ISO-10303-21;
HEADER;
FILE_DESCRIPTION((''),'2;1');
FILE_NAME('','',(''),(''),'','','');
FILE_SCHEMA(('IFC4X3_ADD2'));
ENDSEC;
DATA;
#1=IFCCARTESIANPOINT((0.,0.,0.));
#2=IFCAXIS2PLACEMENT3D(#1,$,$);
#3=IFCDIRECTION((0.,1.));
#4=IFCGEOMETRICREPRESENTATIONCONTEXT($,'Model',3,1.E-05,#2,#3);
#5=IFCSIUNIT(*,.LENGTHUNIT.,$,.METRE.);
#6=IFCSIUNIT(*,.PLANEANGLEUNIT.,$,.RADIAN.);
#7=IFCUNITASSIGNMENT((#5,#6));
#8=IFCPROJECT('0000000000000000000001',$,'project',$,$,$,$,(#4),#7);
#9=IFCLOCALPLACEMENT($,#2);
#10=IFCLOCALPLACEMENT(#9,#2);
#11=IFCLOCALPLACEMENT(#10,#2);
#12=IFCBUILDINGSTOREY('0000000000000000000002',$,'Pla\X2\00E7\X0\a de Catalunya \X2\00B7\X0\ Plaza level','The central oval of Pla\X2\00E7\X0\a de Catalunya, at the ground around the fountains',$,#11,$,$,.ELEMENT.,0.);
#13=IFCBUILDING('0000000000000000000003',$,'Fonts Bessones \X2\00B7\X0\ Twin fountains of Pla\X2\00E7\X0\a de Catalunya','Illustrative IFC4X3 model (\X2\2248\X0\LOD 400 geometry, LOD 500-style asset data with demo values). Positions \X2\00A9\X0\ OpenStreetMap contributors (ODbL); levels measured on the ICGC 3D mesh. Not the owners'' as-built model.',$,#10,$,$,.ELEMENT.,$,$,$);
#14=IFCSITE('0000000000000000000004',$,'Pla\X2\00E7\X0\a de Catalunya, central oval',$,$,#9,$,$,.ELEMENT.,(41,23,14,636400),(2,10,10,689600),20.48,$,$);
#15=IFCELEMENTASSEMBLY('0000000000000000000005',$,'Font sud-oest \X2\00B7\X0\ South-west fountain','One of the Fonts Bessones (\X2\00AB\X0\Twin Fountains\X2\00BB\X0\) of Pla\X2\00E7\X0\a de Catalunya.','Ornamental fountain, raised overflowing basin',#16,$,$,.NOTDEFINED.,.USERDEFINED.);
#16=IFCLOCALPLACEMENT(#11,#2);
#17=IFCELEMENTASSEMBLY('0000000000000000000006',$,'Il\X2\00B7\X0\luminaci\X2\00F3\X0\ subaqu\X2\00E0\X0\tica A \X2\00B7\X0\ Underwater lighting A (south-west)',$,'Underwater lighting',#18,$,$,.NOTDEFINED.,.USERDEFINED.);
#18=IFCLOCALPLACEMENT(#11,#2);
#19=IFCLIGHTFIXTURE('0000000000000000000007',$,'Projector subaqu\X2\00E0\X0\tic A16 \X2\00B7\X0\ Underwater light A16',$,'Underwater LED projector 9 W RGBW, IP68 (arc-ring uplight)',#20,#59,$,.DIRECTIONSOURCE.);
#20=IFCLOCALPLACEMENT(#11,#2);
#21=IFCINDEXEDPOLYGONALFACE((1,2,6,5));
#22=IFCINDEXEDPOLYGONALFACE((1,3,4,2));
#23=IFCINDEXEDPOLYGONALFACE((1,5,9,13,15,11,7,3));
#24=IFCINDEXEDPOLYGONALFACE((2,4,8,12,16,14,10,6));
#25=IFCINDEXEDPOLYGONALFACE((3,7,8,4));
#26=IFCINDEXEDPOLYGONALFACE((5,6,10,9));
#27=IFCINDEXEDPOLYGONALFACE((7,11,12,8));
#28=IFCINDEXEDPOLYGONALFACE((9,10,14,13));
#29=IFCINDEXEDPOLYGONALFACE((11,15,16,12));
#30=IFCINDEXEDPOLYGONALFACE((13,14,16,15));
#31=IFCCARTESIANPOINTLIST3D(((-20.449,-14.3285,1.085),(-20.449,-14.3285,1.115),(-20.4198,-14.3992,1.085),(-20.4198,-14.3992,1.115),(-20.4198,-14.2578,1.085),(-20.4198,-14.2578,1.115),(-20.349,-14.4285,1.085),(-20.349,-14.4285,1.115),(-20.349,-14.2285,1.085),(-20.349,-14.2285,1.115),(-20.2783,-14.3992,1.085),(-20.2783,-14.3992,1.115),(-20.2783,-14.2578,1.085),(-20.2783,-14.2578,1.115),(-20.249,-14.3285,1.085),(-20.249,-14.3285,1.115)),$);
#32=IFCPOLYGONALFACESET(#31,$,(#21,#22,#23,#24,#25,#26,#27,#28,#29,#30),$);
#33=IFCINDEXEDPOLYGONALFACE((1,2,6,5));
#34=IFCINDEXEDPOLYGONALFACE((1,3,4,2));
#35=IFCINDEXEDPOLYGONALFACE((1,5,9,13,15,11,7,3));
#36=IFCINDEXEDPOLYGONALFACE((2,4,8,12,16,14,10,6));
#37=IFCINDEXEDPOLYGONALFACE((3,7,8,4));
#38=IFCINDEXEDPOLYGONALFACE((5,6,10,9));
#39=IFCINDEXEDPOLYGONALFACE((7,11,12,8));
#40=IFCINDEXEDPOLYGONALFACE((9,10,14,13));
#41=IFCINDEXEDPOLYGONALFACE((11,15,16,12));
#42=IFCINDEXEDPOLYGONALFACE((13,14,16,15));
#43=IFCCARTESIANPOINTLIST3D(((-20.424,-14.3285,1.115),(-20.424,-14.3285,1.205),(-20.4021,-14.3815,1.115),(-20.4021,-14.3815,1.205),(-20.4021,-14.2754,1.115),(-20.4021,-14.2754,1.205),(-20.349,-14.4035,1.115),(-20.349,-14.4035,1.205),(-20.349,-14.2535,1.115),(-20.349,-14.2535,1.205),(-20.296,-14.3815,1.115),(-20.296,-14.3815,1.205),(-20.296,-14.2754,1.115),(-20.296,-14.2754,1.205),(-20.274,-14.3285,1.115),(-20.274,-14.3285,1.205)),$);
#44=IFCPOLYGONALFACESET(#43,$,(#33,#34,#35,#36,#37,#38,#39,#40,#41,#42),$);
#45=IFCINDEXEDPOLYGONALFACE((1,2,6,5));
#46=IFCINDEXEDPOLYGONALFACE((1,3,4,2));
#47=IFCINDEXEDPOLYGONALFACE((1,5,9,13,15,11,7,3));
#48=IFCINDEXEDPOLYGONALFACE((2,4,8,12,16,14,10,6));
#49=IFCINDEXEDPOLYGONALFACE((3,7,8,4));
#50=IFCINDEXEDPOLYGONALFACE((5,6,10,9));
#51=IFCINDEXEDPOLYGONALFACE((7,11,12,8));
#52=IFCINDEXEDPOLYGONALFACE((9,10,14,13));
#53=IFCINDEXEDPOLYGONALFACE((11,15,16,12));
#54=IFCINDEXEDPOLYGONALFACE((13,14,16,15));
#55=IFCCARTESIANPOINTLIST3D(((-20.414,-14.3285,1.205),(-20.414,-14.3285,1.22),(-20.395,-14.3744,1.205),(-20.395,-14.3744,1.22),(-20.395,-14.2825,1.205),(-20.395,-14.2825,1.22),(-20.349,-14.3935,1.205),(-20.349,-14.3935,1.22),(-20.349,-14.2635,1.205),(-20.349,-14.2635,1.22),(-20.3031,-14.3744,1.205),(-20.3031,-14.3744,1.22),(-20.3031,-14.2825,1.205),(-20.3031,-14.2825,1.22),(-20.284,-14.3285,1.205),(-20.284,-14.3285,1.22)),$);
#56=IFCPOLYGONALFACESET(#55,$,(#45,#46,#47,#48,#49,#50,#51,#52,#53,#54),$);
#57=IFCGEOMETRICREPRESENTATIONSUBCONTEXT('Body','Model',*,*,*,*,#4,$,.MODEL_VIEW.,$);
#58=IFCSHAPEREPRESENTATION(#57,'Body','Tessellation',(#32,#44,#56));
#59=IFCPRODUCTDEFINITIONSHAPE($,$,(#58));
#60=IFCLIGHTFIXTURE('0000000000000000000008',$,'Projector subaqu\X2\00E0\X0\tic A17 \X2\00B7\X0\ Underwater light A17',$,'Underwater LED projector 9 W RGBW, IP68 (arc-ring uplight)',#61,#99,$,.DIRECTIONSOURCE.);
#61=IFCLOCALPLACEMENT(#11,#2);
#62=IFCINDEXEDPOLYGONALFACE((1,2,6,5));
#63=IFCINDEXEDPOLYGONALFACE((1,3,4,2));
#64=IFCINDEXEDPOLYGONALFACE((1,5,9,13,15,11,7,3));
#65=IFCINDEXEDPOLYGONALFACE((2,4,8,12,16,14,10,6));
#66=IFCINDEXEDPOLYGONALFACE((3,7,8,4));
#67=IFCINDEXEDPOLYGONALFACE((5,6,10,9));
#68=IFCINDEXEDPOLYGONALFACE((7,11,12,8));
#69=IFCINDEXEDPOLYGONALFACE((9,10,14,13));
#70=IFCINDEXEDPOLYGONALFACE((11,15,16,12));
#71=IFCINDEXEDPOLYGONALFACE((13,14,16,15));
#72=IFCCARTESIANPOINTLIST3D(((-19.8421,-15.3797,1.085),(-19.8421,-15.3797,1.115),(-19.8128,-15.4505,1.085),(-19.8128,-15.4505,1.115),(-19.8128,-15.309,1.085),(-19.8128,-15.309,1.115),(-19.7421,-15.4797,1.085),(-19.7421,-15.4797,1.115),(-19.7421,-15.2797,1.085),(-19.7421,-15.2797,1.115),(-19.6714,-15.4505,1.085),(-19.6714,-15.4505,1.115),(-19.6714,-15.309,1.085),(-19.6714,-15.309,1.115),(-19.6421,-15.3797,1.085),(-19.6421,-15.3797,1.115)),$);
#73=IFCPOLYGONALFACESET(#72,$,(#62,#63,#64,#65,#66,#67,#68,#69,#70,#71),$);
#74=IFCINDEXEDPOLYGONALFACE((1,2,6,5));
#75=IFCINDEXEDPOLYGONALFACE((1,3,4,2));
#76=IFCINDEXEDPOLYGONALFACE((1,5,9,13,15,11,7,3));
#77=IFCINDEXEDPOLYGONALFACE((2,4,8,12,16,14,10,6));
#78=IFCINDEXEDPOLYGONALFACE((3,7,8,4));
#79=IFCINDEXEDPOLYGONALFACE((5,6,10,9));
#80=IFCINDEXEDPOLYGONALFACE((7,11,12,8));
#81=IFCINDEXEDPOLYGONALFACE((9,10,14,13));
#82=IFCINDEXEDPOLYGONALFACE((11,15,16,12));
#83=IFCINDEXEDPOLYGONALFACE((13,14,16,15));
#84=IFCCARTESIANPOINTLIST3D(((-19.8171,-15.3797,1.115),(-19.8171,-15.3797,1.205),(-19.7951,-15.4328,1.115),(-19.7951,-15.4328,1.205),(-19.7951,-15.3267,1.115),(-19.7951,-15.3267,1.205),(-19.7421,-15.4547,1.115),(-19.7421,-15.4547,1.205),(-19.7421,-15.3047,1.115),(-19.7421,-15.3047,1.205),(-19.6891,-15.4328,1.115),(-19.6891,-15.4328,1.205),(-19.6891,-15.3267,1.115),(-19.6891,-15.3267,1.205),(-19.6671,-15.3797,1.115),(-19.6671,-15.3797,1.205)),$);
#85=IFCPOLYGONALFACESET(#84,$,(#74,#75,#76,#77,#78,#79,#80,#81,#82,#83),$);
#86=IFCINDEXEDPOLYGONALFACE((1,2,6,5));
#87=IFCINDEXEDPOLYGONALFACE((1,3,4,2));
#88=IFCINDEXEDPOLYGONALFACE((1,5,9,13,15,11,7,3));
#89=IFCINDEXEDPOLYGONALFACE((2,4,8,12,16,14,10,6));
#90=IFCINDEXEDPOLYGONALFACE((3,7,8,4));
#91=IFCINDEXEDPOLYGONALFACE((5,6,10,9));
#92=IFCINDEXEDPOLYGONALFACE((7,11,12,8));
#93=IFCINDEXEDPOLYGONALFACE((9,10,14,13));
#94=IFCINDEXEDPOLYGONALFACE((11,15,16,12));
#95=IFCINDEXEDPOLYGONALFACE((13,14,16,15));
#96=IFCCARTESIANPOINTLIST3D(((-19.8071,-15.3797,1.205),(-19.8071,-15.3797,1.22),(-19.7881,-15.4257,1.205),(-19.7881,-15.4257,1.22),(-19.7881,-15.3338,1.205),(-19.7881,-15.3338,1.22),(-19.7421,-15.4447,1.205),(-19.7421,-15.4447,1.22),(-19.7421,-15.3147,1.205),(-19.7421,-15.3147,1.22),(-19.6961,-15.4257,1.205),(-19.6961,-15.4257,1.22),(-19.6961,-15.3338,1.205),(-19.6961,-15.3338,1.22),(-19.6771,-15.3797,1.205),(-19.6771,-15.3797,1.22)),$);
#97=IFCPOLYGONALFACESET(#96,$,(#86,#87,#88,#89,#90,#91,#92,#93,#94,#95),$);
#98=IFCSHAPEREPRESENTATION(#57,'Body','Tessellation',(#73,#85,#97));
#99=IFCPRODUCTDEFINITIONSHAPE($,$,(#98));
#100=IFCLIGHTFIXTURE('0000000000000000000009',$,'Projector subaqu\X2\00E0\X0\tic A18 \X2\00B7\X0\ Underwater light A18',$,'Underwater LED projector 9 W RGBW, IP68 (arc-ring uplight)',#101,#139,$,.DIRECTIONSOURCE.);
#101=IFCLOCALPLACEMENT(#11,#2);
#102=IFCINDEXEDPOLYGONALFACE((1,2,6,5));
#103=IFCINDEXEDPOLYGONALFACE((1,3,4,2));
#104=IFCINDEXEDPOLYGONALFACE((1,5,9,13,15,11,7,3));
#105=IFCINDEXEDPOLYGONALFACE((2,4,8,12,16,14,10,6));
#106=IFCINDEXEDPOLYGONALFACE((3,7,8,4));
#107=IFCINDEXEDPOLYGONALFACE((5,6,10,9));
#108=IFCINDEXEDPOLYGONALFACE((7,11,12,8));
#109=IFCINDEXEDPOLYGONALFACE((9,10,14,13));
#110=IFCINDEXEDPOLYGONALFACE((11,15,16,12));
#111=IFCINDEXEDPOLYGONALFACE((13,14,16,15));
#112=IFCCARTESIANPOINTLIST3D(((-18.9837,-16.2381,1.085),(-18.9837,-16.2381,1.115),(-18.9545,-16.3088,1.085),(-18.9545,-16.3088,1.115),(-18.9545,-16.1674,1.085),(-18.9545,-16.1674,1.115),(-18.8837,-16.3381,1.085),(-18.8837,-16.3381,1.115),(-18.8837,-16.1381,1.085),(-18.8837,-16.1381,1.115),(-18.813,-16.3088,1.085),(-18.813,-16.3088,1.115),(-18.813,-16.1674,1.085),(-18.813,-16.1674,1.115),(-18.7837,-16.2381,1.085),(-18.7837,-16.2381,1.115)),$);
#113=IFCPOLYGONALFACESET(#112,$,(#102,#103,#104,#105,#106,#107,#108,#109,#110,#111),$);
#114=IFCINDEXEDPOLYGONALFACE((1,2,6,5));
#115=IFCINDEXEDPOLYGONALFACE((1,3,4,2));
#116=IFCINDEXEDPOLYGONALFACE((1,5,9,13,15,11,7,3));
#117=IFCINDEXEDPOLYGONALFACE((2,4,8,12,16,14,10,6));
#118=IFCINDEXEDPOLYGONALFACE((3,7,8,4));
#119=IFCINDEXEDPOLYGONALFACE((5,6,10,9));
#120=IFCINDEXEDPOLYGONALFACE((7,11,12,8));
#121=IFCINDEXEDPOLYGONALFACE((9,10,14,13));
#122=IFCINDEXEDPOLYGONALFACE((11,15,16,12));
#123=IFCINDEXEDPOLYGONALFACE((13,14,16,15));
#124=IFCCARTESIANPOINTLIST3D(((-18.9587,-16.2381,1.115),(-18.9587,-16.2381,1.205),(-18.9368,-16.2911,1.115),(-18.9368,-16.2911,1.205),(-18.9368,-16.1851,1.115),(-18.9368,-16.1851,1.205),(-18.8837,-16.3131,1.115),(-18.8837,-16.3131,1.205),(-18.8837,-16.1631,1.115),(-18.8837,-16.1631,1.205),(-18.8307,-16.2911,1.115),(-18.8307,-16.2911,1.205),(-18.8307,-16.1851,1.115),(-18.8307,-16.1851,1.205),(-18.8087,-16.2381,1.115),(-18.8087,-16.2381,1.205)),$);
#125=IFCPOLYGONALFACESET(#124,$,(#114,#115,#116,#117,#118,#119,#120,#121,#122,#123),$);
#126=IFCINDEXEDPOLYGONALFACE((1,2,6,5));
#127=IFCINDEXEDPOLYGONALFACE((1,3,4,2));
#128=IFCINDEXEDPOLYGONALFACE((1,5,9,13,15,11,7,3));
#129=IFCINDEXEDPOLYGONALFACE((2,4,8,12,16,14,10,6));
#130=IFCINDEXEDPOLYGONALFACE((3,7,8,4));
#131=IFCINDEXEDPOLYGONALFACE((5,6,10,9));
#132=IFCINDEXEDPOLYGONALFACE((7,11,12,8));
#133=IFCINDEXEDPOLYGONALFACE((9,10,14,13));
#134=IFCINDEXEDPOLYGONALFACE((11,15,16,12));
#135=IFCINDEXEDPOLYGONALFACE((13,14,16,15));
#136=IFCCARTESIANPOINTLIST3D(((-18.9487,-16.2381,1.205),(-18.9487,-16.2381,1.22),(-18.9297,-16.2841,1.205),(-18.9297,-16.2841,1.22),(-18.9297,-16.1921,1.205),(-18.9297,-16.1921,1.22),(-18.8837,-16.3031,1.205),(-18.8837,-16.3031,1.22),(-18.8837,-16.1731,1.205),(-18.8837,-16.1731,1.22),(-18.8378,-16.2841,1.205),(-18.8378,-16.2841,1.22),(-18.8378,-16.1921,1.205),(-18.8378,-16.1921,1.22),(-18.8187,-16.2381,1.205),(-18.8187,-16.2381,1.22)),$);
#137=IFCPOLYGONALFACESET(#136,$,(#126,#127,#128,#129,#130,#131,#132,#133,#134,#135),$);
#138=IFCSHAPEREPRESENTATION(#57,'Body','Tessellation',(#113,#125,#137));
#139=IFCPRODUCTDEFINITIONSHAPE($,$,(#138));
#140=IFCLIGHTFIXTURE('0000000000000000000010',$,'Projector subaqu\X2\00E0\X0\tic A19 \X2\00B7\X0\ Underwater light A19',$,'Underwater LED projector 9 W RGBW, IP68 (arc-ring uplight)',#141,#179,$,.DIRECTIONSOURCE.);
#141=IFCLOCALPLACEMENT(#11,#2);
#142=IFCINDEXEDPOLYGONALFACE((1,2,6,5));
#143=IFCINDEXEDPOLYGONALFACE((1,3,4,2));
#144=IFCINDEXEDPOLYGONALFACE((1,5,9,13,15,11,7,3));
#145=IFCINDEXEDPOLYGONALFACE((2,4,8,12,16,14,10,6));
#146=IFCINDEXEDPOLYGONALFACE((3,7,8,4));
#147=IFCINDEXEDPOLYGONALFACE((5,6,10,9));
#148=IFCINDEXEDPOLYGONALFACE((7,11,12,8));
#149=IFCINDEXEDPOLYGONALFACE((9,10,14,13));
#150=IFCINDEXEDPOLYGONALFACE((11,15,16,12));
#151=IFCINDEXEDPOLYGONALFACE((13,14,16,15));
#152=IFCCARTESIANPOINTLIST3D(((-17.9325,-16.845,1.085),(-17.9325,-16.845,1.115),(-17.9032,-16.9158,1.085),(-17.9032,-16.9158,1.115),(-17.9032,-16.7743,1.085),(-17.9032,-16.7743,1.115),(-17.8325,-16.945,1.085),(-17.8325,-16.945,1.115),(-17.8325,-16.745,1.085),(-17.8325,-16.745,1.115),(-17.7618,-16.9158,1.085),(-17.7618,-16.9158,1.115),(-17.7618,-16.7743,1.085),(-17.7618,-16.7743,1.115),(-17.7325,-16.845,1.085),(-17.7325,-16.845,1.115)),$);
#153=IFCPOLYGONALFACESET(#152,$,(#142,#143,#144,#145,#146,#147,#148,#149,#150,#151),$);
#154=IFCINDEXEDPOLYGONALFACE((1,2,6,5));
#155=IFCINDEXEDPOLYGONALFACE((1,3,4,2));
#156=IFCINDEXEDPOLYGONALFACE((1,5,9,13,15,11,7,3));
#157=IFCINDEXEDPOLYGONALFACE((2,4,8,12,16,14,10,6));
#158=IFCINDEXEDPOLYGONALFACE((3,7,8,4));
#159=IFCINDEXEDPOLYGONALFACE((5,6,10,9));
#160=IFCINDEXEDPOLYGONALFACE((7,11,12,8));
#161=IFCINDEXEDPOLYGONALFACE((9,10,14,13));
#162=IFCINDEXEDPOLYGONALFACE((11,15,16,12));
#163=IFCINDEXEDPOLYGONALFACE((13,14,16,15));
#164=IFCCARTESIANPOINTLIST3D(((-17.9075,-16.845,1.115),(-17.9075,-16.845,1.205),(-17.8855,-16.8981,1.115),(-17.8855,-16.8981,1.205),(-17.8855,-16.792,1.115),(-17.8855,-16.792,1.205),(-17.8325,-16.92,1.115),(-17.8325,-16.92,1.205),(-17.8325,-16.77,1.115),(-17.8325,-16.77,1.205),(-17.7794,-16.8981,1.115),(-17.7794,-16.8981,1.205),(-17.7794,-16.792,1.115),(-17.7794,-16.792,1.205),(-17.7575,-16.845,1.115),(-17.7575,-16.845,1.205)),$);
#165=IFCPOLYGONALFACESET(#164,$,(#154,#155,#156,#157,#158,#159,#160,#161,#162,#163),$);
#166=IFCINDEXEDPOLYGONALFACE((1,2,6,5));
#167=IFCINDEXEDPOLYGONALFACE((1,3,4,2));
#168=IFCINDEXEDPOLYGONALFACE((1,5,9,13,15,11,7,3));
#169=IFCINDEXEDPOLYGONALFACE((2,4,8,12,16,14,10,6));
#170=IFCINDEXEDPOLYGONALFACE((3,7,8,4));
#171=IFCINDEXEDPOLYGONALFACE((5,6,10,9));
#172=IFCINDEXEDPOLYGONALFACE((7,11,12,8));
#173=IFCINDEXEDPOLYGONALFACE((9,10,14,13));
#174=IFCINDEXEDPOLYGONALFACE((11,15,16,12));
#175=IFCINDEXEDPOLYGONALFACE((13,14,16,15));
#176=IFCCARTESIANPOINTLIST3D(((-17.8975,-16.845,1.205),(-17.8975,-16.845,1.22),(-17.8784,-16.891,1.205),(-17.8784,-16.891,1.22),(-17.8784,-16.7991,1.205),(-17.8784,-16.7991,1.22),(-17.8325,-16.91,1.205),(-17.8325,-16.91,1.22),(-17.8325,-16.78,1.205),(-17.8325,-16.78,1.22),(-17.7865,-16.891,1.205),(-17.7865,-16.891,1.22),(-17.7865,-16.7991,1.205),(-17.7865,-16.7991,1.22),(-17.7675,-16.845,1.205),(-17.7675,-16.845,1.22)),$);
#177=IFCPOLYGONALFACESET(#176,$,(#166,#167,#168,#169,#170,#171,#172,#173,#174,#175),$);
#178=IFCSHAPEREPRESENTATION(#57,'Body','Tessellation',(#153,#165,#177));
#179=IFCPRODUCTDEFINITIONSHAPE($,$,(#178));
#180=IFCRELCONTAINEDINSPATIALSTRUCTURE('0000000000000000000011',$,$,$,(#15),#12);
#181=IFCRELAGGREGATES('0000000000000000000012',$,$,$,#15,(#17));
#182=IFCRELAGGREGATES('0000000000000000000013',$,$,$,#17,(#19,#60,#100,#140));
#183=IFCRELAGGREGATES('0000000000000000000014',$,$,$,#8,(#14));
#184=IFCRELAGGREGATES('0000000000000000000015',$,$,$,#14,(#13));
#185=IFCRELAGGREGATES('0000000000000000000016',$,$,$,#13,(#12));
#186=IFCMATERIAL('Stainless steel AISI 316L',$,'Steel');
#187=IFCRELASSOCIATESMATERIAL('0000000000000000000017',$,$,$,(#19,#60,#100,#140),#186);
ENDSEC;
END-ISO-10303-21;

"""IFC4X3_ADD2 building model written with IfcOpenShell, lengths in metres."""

from ifc_helpers import new_model, si_unit, direction, frame, origin, place, context, subcontext, project, spatial, polyline, outline, extrude, material, element, aggregate, save


model = new_model("IFC4X3_ADD2")

# Units and contexts
model_context = context("Model", 3, precision=1e-05, world=origin(), true_north=direction((0.0, 1.0)))
body_context = subcontext(model_context, "Body", "Model", "MODEL_VIEW")
ifc_project = project(units=[si_unit("LENGTHUNIT", "METRE"), si_unit("PLANEANGLEUNIT", "RADIAN")], contexts=[model_context])

# Site, building, storey
site_placement = place(None, origin())
site = spatial("IfcSite", under=ifc_project, at=site_placement, Name="Plaça de Catalunya, central oval", CompositionType="ELEMENT", RefLatitude=(41, 23, 14, 636400), RefLongitude=(2, 10, 10, 689600), RefElevation=20.48)
building_placement = place(site_placement, origin())
building = spatial("IfcBuilding", under=site, at=building_placement, Name="Fonts Bessones · Twin fountains of Plaça de Catalunya", Description="Illustrative IFC4X3 model (≈LOD 400 geometry, LOD 500-style asset data with demo values). Positions © OpenStreetMap contributors (ODbL); levels measured on the ICGC 3D mesh. Not the owners' as-built model.", CompositionType="ELEMENT")
storey_placement = place(building_placement, origin())
storey = spatial("IfcBuildingStorey", under=building, at=storey_placement, Name="Plaça de Catalunya · Plaza level", Description="The central oval of Plaça de Catalunya, at the ground around the fountains", CompositionType="ELEMENT", Elevation=0.0)

# Element assemblies, light fixtures
assembly_1_placement = place(building_placement, origin())
assembly_1 = element("IfcElementAssembly", 1, at=assembly_1_placement, inside=storey, Name="Font sud-oest · South-west fountain", Description="One of the Fonts Bessones («Twin Fountains») of Plaça de Catalunya.", ObjectType="Ornamental fountain, raised overflowing basin", AssemblyPlace="NOTDEFINED", PredefinedType="USERDEFINED")
assembly_2_placement = place(building_placement, origin())
assembly_2 = element("IfcElementAssembly", 2, at=assembly_2_placement, Name="Il·luminació subaquàtica A · Underwater lighting A (south-west)", ObjectType="Underwater lighting", AssemblyPlace="NOTDEFINED", PredefinedType="USERDEFINED")
aggregate(assembly_1, [assembly_2])
ifc_material_1 = material(Name="Stainless steel AISI 316L", Category="Steel")
light_fixture_1_placement = place(building_placement, origin())
light_fixture_1 = element("IfcLightFixture", 3, at=light_fixture_1_placement, material=ifc_material_1, Name="Projector subaquàtic A16 · Underwater light A16", ObjectType="Underwater LED projector 9 W RGBW, IP68 (arc-ring uplight)", PredefinedType="DIRECTIONSOURCE", context=body_context, shape_type="SweptSolid", body=[
    extrude(outline(polyline([(-20.249, -14.3285), (-20.2783, -14.2578), (-20.349, -14.2285), (-20.4198, -14.2578), (-20.449, -14.3285), (-20.4198, -14.3992), (-20.349, -14.4285), (-20.2783, -14.3992), (-20.249, -14.3285)])), frame((0.0, 0.0, 1.085)), (0.0, 0.0, 1.0), 0.03),
    extrude(outline(polyline([(-20.274, -14.3285), (-20.296, -14.2754), (-20.349, -14.2535), (-20.4021, -14.2754), (-20.424, -14.3285), (-20.4021, -14.3815), (-20.349, -14.4035), (-20.296, -14.3815), (-20.274, -14.3285)])), frame((0.0, 0.0, 1.115)), (0.0, 0.0, 1.0), 0.09),
    extrude(outline(polyline([(-20.284, -14.3285), (-20.3031, -14.2825), (-20.349, -14.2635), (-20.395, -14.2825), (-20.414, -14.3285), (-20.395, -14.3744), (-20.349, -14.3935), (-20.3031, -14.3744), (-20.284, -14.3285)])), frame((0.0, 0.0, 1.205)), (0.0, 0.0, 1.0), 0.015),
])
light_fixture_2_placement = place(building_placement, origin())
light_fixture_2 = element("IfcLightFixture", 4, at=light_fixture_2_placement, material=ifc_material_1, Name="Projector subaquàtic A17 · Underwater light A17", ObjectType="Underwater LED projector 9 W RGBW, IP68 (arc-ring uplight)", PredefinedType="DIRECTIONSOURCE", context=body_context, shape_type="SweptSolid", body=[
    extrude(outline(polyline([(-19.6421, -15.3797), (-19.6714, -15.309), (-19.7421, -15.2797), (-19.8128, -15.309), (-19.8421, -15.3797), (-19.8128, -15.4505), (-19.7421, -15.4797), (-19.6714, -15.4505), (-19.6421, -15.3797)])), frame((0.0, 0.0, 1.085)), (0.0, 0.0, 1.0), 0.03),
    extrude(outline(polyline([(-19.6671, -15.3797), (-19.6891, -15.3267), (-19.7421, -15.3047), (-19.7951, -15.3267), (-19.8171, -15.3797), (-19.7951, -15.4328), (-19.7421, -15.4547), (-19.6891, -15.4328), (-19.6671, -15.3797)])), frame((0.0, 0.0, 1.115)), (0.0, 0.0, 1.0), 0.09),
    extrude(outline(polyline([(-19.6771, -15.3797), (-19.6961, -15.3338), (-19.7421, -15.3147), (-19.7881, -15.3338), (-19.8071, -15.3797), (-19.7881, -15.4257), (-19.7421, -15.4447), (-19.6961, -15.4257), (-19.6771, -15.3797)])), frame((0.0, 0.0, 1.205)), (0.0, 0.0, 1.0), 0.015),
])
light_fixture_3_placement = place(building_placement, origin())
light_fixture_3 = element("IfcLightFixture", 5, at=light_fixture_3_placement, material=ifc_material_1, Name="Projector subaquàtic A18 · Underwater light A18", ObjectType="Underwater LED projector 9 W RGBW, IP68 (arc-ring uplight)", PredefinedType="DIRECTIONSOURCE", context=body_context, shape_type="SweptSolid", body=[
    extrude(outline(polyline([(-18.7837, -16.2381), (-18.813, -16.1674), (-18.8837, -16.1381), (-18.9545, -16.1674), (-18.9837, -16.2381), (-18.9545, -16.3088), (-18.8837, -16.3381), (-18.813, -16.3088), (-18.7837, -16.2381)])), frame((0.0, 0.0, 1.085)), (0.0, 0.0, 1.0), 0.03),
    extrude(outline(polyline([(-18.8087, -16.2381), (-18.8307, -16.1851), (-18.8837, -16.1631), (-18.9368, -16.1851), (-18.9587, -16.2381), (-18.9368, -16.2911), (-18.8837, -16.3131), (-18.8307, -16.2911), (-18.8087, -16.2381)])), frame((0.0, 0.0, 1.115)), (0.0, 0.0, 1.0), 0.09),
    extrude(outline(polyline([(-18.8187, -16.2381), (-18.8378, -16.1921), (-18.8837, -16.1731), (-18.9297, -16.1921), (-18.9487, -16.2381), (-18.9297, -16.2841), (-18.8837, -16.3031), (-18.8378, -16.2841), (-18.8187, -16.2381)])), frame((0.0, 0.0, 1.205)), (0.0, 0.0, 1.0), 0.015),
])
light_fixture_4_placement = place(building_placement, origin())
light_fixture_4 = element("IfcLightFixture", 6, at=light_fixture_4_placement, material=ifc_material_1, Name="Projector subaquàtic A19 · Underwater light A19", ObjectType="Underwater LED projector 9 W RGBW, IP68 (arc-ring uplight)", PredefinedType="DIRECTIONSOURCE", context=body_context, shape_type="SweptSolid", body=[
    extrude(outline(polyline([(-17.7325, -16.845), (-17.7618, -16.7743), (-17.8325, -16.745), (-17.9032, -16.7743), (-17.9325, -16.845), (-17.9032, -16.9158), (-17.8325, -16.945), (-17.7618, -16.9158), (-17.7325, -16.845)])), frame((0.0, 0.0, 1.085)), (0.0, 0.0, 1.0), 0.03),
    extrude(outline(polyline([(-17.7575, -16.845), (-17.7794, -16.792), (-17.8325, -16.77), (-17.8855, -16.792), (-17.9075, -16.845), (-17.8855, -16.8981), (-17.8325, -16.92), (-17.7794, -16.8981), (-17.7575, -16.845)])), frame((0.0, 0.0, 1.115)), (0.0, 0.0, 1.0), 0.09),
    extrude(outline(polyline([(-17.7675, -16.845), (-17.7865, -16.7991), (-17.8325, -16.78), (-17.8784, -16.7991), (-17.8975, -16.845), (-17.8784, -16.891), (-17.8325, -16.91), (-17.7865, -16.891), (-17.7675, -16.845)])), frame((0.0, 0.0, 1.205)), (0.0, 0.0, 1.0), 0.015),
])
aggregate(assembly_2, [light_fixture_1, light_fixture_2, light_fixture_3, light_fixture_4])

save(model, "model.ifc")
